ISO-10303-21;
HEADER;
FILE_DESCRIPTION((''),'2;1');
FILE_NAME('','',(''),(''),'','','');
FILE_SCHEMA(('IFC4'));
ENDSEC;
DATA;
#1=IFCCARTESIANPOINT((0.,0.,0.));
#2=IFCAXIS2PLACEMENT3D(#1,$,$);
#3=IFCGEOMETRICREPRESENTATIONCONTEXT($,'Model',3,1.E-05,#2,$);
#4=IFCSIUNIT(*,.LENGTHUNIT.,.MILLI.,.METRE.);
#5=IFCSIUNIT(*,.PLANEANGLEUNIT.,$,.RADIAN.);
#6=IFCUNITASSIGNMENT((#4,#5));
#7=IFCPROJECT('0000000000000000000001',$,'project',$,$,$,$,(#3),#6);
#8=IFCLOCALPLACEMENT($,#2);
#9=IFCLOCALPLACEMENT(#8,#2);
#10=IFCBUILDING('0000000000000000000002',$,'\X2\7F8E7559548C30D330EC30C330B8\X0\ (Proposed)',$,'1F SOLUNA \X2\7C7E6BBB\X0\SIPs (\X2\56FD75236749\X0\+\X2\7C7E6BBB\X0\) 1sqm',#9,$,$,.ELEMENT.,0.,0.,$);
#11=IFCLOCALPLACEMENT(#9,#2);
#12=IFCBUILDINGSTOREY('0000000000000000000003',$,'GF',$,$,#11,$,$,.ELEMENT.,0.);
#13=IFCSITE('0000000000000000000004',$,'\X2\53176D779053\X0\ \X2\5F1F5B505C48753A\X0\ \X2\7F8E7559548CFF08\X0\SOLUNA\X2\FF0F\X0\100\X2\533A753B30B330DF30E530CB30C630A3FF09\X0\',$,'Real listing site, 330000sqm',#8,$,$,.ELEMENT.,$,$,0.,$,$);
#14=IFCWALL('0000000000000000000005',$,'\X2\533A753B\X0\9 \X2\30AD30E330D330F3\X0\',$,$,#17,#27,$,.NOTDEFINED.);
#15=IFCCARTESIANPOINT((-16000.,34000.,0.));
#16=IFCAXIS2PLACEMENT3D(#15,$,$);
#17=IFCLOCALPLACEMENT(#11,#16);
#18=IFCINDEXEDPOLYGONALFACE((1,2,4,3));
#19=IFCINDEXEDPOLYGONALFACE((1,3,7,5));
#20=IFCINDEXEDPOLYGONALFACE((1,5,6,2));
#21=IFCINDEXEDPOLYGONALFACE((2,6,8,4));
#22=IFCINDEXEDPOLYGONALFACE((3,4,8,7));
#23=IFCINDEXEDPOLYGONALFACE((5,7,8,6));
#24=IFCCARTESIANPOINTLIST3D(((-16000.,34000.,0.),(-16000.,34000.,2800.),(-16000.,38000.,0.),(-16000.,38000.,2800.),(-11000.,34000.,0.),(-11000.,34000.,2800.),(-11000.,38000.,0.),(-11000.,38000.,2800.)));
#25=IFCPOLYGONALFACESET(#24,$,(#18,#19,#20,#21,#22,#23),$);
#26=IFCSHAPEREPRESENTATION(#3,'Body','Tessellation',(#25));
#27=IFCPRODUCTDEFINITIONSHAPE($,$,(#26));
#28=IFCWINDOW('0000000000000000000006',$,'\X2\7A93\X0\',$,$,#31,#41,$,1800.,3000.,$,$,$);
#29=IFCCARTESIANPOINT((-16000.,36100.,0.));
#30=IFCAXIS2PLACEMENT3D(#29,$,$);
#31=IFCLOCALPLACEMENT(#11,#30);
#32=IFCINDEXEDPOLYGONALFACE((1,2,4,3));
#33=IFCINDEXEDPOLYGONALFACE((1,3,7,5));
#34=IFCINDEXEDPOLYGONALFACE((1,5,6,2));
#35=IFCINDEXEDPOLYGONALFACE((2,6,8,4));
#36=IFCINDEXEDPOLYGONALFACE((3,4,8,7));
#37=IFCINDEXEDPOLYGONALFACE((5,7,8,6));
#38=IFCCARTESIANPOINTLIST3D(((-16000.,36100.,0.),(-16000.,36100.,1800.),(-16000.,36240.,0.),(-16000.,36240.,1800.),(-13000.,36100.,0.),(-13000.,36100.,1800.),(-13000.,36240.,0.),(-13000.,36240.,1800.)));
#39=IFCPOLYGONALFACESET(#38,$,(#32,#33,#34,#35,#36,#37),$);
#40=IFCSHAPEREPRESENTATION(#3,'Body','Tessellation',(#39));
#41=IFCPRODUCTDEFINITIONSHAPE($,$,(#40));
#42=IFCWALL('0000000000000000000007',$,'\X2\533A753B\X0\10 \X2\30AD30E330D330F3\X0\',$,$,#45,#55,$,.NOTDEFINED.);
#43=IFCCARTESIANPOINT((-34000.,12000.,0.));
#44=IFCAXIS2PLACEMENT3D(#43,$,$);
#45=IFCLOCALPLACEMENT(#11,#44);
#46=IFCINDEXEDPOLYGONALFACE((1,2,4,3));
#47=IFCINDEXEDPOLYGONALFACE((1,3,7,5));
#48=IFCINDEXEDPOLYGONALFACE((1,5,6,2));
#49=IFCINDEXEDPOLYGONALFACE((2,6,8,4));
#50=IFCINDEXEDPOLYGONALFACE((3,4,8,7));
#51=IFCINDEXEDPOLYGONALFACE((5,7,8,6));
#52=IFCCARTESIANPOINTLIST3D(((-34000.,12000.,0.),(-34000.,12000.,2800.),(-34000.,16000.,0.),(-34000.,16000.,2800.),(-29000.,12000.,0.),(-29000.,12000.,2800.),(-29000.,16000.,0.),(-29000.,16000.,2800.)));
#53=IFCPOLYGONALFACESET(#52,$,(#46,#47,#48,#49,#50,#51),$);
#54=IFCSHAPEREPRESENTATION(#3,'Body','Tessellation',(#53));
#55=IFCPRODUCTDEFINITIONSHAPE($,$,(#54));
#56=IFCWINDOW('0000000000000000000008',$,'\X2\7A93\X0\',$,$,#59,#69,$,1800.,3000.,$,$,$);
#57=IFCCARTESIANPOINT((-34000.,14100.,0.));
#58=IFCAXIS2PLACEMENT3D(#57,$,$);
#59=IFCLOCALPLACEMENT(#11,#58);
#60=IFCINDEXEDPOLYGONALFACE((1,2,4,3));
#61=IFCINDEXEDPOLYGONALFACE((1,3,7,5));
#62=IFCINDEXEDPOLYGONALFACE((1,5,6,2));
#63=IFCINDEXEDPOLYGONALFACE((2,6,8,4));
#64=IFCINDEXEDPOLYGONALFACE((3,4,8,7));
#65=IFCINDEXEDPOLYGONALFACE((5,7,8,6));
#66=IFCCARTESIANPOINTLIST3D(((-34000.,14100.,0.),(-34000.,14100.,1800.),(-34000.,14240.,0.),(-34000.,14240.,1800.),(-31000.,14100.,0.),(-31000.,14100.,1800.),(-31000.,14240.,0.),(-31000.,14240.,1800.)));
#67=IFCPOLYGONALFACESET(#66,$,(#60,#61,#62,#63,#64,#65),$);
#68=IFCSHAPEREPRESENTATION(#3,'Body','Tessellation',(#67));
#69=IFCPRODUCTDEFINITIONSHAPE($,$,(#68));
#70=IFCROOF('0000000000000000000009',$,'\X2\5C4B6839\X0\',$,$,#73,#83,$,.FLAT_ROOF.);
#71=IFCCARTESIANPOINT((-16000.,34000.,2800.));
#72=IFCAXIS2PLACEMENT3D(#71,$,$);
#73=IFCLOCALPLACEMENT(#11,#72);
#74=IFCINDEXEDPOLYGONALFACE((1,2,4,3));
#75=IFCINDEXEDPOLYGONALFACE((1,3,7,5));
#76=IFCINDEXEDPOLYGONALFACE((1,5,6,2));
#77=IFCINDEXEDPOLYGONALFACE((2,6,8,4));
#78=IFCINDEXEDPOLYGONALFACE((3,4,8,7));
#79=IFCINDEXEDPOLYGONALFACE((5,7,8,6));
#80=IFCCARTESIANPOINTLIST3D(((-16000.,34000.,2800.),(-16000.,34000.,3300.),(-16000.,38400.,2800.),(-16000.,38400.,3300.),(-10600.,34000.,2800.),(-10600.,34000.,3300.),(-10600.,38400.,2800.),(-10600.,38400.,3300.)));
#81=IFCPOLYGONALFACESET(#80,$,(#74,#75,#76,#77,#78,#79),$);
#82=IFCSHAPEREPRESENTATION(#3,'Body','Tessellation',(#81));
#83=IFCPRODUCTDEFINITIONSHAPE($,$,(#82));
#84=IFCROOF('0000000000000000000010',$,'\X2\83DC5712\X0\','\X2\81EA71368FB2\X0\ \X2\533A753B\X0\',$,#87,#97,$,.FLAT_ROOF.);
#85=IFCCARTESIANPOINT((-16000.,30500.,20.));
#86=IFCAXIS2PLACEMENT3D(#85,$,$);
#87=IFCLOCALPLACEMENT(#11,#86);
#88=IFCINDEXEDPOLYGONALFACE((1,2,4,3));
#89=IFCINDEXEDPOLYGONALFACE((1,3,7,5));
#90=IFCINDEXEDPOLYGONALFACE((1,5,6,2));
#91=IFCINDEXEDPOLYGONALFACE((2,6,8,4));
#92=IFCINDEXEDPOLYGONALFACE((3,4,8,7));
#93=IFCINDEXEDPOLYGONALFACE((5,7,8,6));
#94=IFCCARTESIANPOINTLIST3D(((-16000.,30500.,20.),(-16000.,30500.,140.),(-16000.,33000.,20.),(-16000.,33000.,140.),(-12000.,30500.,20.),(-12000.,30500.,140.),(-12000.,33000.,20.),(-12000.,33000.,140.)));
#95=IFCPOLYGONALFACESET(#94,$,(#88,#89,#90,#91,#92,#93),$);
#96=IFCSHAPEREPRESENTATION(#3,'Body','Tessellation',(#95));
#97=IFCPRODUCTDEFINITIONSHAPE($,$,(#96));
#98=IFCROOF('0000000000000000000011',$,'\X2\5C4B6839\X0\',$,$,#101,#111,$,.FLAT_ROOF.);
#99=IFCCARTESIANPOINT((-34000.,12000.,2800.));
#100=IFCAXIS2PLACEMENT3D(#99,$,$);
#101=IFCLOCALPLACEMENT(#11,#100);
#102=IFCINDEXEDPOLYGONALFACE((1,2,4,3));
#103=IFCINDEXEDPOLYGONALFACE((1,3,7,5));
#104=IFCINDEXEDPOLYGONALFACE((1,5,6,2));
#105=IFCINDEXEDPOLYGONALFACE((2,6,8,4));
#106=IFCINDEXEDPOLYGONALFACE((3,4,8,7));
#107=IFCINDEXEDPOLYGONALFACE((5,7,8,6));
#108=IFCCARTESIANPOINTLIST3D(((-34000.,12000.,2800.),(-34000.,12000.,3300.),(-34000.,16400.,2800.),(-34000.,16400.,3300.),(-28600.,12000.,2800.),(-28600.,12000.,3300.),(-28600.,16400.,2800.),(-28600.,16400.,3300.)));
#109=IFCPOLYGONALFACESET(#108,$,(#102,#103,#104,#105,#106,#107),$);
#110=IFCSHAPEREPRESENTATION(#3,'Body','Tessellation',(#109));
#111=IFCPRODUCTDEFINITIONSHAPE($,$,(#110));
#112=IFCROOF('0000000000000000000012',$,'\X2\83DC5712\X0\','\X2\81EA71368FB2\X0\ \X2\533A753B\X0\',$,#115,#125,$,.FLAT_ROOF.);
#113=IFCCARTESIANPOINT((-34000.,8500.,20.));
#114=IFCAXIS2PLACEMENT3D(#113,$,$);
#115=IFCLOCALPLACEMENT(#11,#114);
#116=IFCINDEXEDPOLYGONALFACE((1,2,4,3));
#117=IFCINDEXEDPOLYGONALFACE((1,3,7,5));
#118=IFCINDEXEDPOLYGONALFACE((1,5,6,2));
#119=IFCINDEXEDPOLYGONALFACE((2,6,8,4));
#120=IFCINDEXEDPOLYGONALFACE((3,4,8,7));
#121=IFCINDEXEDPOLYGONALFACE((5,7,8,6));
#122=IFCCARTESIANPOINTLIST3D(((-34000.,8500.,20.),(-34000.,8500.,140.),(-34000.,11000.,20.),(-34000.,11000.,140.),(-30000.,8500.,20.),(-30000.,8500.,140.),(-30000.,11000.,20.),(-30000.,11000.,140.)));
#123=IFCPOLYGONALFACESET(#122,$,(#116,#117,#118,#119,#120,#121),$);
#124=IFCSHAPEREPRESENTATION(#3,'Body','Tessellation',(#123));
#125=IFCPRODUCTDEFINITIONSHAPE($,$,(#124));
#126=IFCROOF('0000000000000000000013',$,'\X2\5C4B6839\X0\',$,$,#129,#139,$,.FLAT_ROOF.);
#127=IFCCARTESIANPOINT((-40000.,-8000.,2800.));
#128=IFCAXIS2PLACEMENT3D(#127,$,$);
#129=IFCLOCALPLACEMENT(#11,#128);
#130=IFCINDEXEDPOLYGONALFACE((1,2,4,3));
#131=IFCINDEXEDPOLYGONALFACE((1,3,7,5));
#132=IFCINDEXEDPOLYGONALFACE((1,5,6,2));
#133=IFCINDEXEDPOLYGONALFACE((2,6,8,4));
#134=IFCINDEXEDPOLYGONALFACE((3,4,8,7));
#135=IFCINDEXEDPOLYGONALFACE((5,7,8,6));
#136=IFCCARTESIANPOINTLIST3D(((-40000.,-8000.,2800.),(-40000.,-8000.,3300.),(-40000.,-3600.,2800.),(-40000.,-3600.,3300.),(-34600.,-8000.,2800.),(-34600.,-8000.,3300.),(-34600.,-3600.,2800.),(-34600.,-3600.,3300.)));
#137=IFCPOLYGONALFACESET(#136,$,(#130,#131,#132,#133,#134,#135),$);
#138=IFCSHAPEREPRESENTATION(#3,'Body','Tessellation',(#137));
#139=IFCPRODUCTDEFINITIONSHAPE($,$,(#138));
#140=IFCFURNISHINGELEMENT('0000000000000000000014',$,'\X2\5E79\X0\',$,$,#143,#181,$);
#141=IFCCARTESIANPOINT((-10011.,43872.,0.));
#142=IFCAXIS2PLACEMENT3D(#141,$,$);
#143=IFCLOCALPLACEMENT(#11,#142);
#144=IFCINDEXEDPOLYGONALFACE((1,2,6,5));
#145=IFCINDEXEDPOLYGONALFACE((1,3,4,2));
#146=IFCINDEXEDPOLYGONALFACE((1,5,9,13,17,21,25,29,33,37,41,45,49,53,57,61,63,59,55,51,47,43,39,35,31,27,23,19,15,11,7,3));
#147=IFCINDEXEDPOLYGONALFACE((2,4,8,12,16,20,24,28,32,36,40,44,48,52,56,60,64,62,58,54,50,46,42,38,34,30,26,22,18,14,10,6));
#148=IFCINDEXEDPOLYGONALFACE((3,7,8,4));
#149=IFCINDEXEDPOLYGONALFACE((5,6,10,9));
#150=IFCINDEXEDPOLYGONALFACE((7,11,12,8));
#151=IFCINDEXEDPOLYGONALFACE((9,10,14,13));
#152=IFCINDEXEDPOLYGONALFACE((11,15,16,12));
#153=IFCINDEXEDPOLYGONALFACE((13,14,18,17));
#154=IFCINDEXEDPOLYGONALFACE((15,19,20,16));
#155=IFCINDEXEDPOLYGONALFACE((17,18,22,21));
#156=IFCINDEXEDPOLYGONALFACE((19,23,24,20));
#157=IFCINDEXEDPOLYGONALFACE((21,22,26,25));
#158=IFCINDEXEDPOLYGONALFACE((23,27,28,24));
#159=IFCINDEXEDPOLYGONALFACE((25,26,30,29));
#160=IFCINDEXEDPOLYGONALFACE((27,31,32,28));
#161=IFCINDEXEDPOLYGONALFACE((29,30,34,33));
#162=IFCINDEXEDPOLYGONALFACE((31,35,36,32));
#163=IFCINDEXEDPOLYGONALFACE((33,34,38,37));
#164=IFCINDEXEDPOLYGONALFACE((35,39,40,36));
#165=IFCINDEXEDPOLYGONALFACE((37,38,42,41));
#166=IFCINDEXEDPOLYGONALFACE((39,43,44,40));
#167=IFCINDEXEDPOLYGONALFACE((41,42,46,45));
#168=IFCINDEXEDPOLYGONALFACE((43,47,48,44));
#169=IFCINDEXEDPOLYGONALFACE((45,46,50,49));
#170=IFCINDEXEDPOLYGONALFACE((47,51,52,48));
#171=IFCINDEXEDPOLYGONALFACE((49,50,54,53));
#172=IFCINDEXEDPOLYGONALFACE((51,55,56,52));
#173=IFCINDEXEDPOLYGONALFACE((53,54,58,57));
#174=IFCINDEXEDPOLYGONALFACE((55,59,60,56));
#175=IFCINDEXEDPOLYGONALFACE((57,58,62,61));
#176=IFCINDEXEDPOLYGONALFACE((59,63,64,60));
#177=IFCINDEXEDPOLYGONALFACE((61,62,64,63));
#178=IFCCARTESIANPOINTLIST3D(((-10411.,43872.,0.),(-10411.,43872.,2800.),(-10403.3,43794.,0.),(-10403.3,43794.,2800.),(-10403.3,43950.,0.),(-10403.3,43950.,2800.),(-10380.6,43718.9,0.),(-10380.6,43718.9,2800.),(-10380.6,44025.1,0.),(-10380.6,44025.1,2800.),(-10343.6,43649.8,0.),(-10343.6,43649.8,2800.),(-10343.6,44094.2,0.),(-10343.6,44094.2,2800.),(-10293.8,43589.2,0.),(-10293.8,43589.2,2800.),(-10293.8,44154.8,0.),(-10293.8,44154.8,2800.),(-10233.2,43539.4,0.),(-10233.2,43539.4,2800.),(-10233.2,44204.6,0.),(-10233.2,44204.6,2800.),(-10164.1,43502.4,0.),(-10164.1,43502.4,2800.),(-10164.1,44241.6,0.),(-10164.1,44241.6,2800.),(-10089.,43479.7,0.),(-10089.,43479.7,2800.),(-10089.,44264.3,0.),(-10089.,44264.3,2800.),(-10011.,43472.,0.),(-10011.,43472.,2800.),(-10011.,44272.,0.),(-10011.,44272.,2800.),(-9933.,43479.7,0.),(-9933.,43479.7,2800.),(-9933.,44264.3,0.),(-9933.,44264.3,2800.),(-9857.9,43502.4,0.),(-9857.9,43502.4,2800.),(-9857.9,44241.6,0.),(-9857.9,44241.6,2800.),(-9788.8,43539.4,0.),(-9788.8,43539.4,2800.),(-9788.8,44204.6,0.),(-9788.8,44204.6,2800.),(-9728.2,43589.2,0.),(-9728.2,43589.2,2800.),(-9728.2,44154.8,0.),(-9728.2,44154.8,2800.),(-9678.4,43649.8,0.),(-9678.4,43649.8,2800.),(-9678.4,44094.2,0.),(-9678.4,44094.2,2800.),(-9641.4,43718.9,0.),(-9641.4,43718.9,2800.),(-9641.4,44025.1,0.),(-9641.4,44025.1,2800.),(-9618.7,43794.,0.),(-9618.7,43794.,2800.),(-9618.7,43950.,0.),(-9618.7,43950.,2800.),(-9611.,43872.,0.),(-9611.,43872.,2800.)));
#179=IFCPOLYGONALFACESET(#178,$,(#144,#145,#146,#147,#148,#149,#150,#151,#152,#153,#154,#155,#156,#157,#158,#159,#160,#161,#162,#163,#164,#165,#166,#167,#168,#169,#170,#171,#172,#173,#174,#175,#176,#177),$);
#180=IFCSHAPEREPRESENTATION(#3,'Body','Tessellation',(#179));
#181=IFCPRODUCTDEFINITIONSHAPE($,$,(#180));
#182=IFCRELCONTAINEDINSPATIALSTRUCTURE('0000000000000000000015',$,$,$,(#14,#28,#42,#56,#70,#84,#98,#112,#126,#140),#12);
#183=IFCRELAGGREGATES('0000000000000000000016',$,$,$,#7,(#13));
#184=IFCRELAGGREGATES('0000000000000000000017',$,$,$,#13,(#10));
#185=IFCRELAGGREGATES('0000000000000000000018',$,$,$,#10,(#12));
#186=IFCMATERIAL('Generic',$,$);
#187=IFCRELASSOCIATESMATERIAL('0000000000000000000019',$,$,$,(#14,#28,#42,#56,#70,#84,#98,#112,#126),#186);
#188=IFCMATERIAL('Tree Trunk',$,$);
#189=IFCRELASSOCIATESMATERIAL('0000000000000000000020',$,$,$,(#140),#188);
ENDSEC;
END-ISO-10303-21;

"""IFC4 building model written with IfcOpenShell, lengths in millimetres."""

from ifc_helpers import new_model, si_unit, frame, frame_2d, origin, origin_2d, place, context, project, spatial, rectangle, circle, extrude, material, element, fill, save


model = new_model("IFC4")

# Units and contexts
model_context = context("Model", 3, precision=1e-05, world=origin())
ifc_project = project(units=[si_unit("LENGTHUNIT", "METRE", prefix="MILLI"), si_unit("PLANEANGLEUNIT", "RADIAN")], contexts=[model_context])

# Site, building, storey
site_placement = place(None, origin())
site = spatial("IfcSite", under=ifc_project, at=site_placement, Name="北海道 弟子屈町 美留和（SOLUNA／100区画コミュニティ）", ObjectType="Real listing site, 330000sqm", CompositionType="ELEMENT", RefElevation=0.0)
building_placement = place(site_placement, origin())
building = spatial("IfcBuilding", under=site, at=building_placement, Name="美留和ビレッジ (Proposed)", ObjectType="1F SOLUNA 籾殻SIPs (国産杉+籾殻) 1sqm", CompositionType="ELEMENT", ElevationOfRefHeight=0.0, ElevationOfTerrain=0.0)
storey_placement = place(building_placement, origin())
storey = spatial("IfcBuildingStorey", under=building, at=storey_placement, Name="GF", CompositionType="ELEMENT", Elevation=0.0)

# Walls, openings, windows
ifc_material_1 = material(Name="Generic")
wall_1_placement = place(storey_placement, frame((-16000.0, 34000.0, 0.0)))
wall_1 = element("IfcWall", 1, at=wall_1_placement, inside=storey, material=ifc_material_1, Name="区画9 キャビン", PredefinedType="NOTDEFINED", context=model_context, shape_type="SweptSolid", body=[
    extrude(rectangle(XDim=5000.0, YDim=4000.0, at=frame_2d((2500.0, 2000.0))), frame((-16000.0, 34000.0, 0.0)), (0.0, 0.0, 1.0), 2800.0),
])
opening_1_placement = place(storey_placement, frame((-16000.0, 36100.0, 0.0)))
opening_1 = element("IfcOpeningElement", 2, at=opening_1_placement, cuts=wall_1, PredefinedType="NOTDEFINED", context=model_context, shape_type="SweptSolid", body=[
    extrude(rectangle(XDim=3000.0, YDim=140.0, at=frame_2d((1500.0, 70.0))), frame((-16000.0, 36100.0, 0.0)), (0.0, 0.0, 1.0), 1800.0),
])
window_1_placement = place(storey_placement, frame((-16000.0, 36100.0, 0.0)))
window_1 = element("IfcWindow", 3, at=window_1_placement, inside=storey, material=ifc_material_1, Name="窓", OverallHeight=1800.0, OverallWidth=3000.0, context=model_context, shape_type="SweptSolid", body=[
    extrude(rectangle(XDim=3000.0, YDim=140.0, at=frame_2d((1500.0, 70.0))), frame((-16000.0, 36100.0, 0.0)), (0.0, 0.0, 1.0), 1800.0),
])
fill(opening_1, window_1)
wall_2_placement = place(storey_placement, frame((-34000.0, 12000.0, 0.0)))
wall_2 = element("IfcWall", 4, at=wall_2_placement, inside=storey, material=ifc_material_1, Name="区画10 キャビン", PredefinedType="NOTDEFINED", context=model_context, shape_type="SweptSolid", body=[
    extrude(rectangle(XDim=5000.0, YDim=4000.0, at=frame_2d((2500.0, 2000.0))), frame((-34000.0, 12000.0, 0.0)), (0.0, 0.0, 1.0), 2800.0),
])
opening_2_placement = place(storey_placement, frame((-34000.0, 14100.0, 0.0)))
opening_2 = element("IfcOpeningElement", 5, at=opening_2_placement, cuts=wall_2, PredefinedType="NOTDEFINED", context=model_context, shape_type="SweptSolid", body=[
    extrude(rectangle(XDim=3000.0, YDim=140.0, at=frame_2d((1500.0, 70.0))), frame((-34000.0, 14100.0, 0.0)), (0.0, 0.0, 1.0), 1800.0),
])
window_2_placement = place(storey_placement, frame((-34000.0, 14100.0, 0.0)))
window_2 = element("IfcWindow", 6, at=window_2_placement, inside=storey, material=ifc_material_1, Name="窓", OverallHeight=1800.0, OverallWidth=3000.0, context=model_context, shape_type="SweptSolid", body=[
    extrude(rectangle(XDim=3000.0, YDim=140.0, at=frame_2d((1500.0, 70.0))), frame((-34000.0, 14100.0, 0.0)), (0.0, 0.0, 1.0), 1800.0),
])
fill(opening_2, window_2)

# Roofs
roof_1_placement = place(storey_placement, frame((-16000.0, 34000.0, 2800.0)))
element("IfcRoof", 7, at=roof_1_placement, inside=storey, material=ifc_material_1, Name="屋根", PredefinedType="FLAT_ROOF", context=model_context, shape_type="SweptSolid", body=[
    extrude(rectangle(XDim=5400.0, YDim=4400.0, at=frame_2d((2700.0, 2200.0))), frame((-16000.0, 34000.0, 2800.0)), (0.0, 0.0, 1.0), 500.0),
])
roof_2_placement = place(storey_placement, frame((-16000.0, 30500.0, 20.0)))
element("IfcRoof", 8, at=roof_2_placement, inside=storey, material=ifc_material_1, Name="菜園", Description="自然農 区画", PredefinedType="FLAT_ROOF", context=model_context, shape_type="SweptSolid", body=[
    extrude(rectangle(XDim=4000.0, YDim=2500.0, at=frame_2d((2000.0, 1250.0))), frame((-16000.0, 30500.0, 20.0)), (0.0, 0.0, 1.0), 120.0),
])
roof_3_placement = place(storey_placement, frame((-34000.0, 12000.0, 2800.0)))
element("IfcRoof", 9, at=roof_3_placement, inside=storey, material=ifc_material_1, Name="屋根", PredefinedType="FLAT_ROOF", context=model_context, shape_type="SweptSolid", body=[
    extrude(rectangle(XDim=5400.0, YDim=4400.0, at=frame_2d((2700.0, 2200.0))), frame((-34000.0, 12000.0, 2800.0)), (0.0, 0.0, 1.0), 500.0),
])
roof_4_placement = place(storey_placement, frame((-34000.0, 8500.0, 20.0)))
element("IfcRoof", 10, at=roof_4_placement, inside=storey, material=ifc_material_1, Name="菜園", Description="自然農 区画", PredefinedType="FLAT_ROOF", context=model_context, shape_type="SweptSolid", body=[
    extrude(rectangle(XDim=4000.0, YDim=2500.0, at=frame_2d((2000.0, 1250.0))), frame((-34000.0, 8500.0, 20.0)), (0.0, 0.0, 1.0), 120.0),
])
roof_5_placement = place(storey_placement, frame((-40000.0, -8000.0, 2800.0)))
element("IfcRoof", 11, at=roof_5_placement, inside=storey, material=ifc_material_1, Name="屋根", PredefinedType="FLAT_ROOF", context=model_context, shape_type="SweptSolid", body=[
    extrude(rectangle(XDim=5400.0, YDim=4400.0, at=frame_2d((2700.0, 2200.0))), frame((-40000.0, -8000.0, 2800.0)), (0.0, 0.0, 1.0), 500.0),
])

# Furnishing element
ifc_material_2 = material(Name="Tree Trunk")
furnishing_1_placement = place(storey_placement, frame((-10011.0, 43872.0, 0.0)))
element("IfcFurnishingElement", 12, at=furnishing_1_placement, inside=storey, material=ifc_material_2, Name="幹", context=model_context, shape_type="SweptSolid", body=[
    extrude(circle(Radius=400.0, at=origin_2d()), frame((-10011.0, 43872.0, 0.0)), (0.0, 0.0, 1.0), 2800.0),
])

save(model, "model.ifc")
